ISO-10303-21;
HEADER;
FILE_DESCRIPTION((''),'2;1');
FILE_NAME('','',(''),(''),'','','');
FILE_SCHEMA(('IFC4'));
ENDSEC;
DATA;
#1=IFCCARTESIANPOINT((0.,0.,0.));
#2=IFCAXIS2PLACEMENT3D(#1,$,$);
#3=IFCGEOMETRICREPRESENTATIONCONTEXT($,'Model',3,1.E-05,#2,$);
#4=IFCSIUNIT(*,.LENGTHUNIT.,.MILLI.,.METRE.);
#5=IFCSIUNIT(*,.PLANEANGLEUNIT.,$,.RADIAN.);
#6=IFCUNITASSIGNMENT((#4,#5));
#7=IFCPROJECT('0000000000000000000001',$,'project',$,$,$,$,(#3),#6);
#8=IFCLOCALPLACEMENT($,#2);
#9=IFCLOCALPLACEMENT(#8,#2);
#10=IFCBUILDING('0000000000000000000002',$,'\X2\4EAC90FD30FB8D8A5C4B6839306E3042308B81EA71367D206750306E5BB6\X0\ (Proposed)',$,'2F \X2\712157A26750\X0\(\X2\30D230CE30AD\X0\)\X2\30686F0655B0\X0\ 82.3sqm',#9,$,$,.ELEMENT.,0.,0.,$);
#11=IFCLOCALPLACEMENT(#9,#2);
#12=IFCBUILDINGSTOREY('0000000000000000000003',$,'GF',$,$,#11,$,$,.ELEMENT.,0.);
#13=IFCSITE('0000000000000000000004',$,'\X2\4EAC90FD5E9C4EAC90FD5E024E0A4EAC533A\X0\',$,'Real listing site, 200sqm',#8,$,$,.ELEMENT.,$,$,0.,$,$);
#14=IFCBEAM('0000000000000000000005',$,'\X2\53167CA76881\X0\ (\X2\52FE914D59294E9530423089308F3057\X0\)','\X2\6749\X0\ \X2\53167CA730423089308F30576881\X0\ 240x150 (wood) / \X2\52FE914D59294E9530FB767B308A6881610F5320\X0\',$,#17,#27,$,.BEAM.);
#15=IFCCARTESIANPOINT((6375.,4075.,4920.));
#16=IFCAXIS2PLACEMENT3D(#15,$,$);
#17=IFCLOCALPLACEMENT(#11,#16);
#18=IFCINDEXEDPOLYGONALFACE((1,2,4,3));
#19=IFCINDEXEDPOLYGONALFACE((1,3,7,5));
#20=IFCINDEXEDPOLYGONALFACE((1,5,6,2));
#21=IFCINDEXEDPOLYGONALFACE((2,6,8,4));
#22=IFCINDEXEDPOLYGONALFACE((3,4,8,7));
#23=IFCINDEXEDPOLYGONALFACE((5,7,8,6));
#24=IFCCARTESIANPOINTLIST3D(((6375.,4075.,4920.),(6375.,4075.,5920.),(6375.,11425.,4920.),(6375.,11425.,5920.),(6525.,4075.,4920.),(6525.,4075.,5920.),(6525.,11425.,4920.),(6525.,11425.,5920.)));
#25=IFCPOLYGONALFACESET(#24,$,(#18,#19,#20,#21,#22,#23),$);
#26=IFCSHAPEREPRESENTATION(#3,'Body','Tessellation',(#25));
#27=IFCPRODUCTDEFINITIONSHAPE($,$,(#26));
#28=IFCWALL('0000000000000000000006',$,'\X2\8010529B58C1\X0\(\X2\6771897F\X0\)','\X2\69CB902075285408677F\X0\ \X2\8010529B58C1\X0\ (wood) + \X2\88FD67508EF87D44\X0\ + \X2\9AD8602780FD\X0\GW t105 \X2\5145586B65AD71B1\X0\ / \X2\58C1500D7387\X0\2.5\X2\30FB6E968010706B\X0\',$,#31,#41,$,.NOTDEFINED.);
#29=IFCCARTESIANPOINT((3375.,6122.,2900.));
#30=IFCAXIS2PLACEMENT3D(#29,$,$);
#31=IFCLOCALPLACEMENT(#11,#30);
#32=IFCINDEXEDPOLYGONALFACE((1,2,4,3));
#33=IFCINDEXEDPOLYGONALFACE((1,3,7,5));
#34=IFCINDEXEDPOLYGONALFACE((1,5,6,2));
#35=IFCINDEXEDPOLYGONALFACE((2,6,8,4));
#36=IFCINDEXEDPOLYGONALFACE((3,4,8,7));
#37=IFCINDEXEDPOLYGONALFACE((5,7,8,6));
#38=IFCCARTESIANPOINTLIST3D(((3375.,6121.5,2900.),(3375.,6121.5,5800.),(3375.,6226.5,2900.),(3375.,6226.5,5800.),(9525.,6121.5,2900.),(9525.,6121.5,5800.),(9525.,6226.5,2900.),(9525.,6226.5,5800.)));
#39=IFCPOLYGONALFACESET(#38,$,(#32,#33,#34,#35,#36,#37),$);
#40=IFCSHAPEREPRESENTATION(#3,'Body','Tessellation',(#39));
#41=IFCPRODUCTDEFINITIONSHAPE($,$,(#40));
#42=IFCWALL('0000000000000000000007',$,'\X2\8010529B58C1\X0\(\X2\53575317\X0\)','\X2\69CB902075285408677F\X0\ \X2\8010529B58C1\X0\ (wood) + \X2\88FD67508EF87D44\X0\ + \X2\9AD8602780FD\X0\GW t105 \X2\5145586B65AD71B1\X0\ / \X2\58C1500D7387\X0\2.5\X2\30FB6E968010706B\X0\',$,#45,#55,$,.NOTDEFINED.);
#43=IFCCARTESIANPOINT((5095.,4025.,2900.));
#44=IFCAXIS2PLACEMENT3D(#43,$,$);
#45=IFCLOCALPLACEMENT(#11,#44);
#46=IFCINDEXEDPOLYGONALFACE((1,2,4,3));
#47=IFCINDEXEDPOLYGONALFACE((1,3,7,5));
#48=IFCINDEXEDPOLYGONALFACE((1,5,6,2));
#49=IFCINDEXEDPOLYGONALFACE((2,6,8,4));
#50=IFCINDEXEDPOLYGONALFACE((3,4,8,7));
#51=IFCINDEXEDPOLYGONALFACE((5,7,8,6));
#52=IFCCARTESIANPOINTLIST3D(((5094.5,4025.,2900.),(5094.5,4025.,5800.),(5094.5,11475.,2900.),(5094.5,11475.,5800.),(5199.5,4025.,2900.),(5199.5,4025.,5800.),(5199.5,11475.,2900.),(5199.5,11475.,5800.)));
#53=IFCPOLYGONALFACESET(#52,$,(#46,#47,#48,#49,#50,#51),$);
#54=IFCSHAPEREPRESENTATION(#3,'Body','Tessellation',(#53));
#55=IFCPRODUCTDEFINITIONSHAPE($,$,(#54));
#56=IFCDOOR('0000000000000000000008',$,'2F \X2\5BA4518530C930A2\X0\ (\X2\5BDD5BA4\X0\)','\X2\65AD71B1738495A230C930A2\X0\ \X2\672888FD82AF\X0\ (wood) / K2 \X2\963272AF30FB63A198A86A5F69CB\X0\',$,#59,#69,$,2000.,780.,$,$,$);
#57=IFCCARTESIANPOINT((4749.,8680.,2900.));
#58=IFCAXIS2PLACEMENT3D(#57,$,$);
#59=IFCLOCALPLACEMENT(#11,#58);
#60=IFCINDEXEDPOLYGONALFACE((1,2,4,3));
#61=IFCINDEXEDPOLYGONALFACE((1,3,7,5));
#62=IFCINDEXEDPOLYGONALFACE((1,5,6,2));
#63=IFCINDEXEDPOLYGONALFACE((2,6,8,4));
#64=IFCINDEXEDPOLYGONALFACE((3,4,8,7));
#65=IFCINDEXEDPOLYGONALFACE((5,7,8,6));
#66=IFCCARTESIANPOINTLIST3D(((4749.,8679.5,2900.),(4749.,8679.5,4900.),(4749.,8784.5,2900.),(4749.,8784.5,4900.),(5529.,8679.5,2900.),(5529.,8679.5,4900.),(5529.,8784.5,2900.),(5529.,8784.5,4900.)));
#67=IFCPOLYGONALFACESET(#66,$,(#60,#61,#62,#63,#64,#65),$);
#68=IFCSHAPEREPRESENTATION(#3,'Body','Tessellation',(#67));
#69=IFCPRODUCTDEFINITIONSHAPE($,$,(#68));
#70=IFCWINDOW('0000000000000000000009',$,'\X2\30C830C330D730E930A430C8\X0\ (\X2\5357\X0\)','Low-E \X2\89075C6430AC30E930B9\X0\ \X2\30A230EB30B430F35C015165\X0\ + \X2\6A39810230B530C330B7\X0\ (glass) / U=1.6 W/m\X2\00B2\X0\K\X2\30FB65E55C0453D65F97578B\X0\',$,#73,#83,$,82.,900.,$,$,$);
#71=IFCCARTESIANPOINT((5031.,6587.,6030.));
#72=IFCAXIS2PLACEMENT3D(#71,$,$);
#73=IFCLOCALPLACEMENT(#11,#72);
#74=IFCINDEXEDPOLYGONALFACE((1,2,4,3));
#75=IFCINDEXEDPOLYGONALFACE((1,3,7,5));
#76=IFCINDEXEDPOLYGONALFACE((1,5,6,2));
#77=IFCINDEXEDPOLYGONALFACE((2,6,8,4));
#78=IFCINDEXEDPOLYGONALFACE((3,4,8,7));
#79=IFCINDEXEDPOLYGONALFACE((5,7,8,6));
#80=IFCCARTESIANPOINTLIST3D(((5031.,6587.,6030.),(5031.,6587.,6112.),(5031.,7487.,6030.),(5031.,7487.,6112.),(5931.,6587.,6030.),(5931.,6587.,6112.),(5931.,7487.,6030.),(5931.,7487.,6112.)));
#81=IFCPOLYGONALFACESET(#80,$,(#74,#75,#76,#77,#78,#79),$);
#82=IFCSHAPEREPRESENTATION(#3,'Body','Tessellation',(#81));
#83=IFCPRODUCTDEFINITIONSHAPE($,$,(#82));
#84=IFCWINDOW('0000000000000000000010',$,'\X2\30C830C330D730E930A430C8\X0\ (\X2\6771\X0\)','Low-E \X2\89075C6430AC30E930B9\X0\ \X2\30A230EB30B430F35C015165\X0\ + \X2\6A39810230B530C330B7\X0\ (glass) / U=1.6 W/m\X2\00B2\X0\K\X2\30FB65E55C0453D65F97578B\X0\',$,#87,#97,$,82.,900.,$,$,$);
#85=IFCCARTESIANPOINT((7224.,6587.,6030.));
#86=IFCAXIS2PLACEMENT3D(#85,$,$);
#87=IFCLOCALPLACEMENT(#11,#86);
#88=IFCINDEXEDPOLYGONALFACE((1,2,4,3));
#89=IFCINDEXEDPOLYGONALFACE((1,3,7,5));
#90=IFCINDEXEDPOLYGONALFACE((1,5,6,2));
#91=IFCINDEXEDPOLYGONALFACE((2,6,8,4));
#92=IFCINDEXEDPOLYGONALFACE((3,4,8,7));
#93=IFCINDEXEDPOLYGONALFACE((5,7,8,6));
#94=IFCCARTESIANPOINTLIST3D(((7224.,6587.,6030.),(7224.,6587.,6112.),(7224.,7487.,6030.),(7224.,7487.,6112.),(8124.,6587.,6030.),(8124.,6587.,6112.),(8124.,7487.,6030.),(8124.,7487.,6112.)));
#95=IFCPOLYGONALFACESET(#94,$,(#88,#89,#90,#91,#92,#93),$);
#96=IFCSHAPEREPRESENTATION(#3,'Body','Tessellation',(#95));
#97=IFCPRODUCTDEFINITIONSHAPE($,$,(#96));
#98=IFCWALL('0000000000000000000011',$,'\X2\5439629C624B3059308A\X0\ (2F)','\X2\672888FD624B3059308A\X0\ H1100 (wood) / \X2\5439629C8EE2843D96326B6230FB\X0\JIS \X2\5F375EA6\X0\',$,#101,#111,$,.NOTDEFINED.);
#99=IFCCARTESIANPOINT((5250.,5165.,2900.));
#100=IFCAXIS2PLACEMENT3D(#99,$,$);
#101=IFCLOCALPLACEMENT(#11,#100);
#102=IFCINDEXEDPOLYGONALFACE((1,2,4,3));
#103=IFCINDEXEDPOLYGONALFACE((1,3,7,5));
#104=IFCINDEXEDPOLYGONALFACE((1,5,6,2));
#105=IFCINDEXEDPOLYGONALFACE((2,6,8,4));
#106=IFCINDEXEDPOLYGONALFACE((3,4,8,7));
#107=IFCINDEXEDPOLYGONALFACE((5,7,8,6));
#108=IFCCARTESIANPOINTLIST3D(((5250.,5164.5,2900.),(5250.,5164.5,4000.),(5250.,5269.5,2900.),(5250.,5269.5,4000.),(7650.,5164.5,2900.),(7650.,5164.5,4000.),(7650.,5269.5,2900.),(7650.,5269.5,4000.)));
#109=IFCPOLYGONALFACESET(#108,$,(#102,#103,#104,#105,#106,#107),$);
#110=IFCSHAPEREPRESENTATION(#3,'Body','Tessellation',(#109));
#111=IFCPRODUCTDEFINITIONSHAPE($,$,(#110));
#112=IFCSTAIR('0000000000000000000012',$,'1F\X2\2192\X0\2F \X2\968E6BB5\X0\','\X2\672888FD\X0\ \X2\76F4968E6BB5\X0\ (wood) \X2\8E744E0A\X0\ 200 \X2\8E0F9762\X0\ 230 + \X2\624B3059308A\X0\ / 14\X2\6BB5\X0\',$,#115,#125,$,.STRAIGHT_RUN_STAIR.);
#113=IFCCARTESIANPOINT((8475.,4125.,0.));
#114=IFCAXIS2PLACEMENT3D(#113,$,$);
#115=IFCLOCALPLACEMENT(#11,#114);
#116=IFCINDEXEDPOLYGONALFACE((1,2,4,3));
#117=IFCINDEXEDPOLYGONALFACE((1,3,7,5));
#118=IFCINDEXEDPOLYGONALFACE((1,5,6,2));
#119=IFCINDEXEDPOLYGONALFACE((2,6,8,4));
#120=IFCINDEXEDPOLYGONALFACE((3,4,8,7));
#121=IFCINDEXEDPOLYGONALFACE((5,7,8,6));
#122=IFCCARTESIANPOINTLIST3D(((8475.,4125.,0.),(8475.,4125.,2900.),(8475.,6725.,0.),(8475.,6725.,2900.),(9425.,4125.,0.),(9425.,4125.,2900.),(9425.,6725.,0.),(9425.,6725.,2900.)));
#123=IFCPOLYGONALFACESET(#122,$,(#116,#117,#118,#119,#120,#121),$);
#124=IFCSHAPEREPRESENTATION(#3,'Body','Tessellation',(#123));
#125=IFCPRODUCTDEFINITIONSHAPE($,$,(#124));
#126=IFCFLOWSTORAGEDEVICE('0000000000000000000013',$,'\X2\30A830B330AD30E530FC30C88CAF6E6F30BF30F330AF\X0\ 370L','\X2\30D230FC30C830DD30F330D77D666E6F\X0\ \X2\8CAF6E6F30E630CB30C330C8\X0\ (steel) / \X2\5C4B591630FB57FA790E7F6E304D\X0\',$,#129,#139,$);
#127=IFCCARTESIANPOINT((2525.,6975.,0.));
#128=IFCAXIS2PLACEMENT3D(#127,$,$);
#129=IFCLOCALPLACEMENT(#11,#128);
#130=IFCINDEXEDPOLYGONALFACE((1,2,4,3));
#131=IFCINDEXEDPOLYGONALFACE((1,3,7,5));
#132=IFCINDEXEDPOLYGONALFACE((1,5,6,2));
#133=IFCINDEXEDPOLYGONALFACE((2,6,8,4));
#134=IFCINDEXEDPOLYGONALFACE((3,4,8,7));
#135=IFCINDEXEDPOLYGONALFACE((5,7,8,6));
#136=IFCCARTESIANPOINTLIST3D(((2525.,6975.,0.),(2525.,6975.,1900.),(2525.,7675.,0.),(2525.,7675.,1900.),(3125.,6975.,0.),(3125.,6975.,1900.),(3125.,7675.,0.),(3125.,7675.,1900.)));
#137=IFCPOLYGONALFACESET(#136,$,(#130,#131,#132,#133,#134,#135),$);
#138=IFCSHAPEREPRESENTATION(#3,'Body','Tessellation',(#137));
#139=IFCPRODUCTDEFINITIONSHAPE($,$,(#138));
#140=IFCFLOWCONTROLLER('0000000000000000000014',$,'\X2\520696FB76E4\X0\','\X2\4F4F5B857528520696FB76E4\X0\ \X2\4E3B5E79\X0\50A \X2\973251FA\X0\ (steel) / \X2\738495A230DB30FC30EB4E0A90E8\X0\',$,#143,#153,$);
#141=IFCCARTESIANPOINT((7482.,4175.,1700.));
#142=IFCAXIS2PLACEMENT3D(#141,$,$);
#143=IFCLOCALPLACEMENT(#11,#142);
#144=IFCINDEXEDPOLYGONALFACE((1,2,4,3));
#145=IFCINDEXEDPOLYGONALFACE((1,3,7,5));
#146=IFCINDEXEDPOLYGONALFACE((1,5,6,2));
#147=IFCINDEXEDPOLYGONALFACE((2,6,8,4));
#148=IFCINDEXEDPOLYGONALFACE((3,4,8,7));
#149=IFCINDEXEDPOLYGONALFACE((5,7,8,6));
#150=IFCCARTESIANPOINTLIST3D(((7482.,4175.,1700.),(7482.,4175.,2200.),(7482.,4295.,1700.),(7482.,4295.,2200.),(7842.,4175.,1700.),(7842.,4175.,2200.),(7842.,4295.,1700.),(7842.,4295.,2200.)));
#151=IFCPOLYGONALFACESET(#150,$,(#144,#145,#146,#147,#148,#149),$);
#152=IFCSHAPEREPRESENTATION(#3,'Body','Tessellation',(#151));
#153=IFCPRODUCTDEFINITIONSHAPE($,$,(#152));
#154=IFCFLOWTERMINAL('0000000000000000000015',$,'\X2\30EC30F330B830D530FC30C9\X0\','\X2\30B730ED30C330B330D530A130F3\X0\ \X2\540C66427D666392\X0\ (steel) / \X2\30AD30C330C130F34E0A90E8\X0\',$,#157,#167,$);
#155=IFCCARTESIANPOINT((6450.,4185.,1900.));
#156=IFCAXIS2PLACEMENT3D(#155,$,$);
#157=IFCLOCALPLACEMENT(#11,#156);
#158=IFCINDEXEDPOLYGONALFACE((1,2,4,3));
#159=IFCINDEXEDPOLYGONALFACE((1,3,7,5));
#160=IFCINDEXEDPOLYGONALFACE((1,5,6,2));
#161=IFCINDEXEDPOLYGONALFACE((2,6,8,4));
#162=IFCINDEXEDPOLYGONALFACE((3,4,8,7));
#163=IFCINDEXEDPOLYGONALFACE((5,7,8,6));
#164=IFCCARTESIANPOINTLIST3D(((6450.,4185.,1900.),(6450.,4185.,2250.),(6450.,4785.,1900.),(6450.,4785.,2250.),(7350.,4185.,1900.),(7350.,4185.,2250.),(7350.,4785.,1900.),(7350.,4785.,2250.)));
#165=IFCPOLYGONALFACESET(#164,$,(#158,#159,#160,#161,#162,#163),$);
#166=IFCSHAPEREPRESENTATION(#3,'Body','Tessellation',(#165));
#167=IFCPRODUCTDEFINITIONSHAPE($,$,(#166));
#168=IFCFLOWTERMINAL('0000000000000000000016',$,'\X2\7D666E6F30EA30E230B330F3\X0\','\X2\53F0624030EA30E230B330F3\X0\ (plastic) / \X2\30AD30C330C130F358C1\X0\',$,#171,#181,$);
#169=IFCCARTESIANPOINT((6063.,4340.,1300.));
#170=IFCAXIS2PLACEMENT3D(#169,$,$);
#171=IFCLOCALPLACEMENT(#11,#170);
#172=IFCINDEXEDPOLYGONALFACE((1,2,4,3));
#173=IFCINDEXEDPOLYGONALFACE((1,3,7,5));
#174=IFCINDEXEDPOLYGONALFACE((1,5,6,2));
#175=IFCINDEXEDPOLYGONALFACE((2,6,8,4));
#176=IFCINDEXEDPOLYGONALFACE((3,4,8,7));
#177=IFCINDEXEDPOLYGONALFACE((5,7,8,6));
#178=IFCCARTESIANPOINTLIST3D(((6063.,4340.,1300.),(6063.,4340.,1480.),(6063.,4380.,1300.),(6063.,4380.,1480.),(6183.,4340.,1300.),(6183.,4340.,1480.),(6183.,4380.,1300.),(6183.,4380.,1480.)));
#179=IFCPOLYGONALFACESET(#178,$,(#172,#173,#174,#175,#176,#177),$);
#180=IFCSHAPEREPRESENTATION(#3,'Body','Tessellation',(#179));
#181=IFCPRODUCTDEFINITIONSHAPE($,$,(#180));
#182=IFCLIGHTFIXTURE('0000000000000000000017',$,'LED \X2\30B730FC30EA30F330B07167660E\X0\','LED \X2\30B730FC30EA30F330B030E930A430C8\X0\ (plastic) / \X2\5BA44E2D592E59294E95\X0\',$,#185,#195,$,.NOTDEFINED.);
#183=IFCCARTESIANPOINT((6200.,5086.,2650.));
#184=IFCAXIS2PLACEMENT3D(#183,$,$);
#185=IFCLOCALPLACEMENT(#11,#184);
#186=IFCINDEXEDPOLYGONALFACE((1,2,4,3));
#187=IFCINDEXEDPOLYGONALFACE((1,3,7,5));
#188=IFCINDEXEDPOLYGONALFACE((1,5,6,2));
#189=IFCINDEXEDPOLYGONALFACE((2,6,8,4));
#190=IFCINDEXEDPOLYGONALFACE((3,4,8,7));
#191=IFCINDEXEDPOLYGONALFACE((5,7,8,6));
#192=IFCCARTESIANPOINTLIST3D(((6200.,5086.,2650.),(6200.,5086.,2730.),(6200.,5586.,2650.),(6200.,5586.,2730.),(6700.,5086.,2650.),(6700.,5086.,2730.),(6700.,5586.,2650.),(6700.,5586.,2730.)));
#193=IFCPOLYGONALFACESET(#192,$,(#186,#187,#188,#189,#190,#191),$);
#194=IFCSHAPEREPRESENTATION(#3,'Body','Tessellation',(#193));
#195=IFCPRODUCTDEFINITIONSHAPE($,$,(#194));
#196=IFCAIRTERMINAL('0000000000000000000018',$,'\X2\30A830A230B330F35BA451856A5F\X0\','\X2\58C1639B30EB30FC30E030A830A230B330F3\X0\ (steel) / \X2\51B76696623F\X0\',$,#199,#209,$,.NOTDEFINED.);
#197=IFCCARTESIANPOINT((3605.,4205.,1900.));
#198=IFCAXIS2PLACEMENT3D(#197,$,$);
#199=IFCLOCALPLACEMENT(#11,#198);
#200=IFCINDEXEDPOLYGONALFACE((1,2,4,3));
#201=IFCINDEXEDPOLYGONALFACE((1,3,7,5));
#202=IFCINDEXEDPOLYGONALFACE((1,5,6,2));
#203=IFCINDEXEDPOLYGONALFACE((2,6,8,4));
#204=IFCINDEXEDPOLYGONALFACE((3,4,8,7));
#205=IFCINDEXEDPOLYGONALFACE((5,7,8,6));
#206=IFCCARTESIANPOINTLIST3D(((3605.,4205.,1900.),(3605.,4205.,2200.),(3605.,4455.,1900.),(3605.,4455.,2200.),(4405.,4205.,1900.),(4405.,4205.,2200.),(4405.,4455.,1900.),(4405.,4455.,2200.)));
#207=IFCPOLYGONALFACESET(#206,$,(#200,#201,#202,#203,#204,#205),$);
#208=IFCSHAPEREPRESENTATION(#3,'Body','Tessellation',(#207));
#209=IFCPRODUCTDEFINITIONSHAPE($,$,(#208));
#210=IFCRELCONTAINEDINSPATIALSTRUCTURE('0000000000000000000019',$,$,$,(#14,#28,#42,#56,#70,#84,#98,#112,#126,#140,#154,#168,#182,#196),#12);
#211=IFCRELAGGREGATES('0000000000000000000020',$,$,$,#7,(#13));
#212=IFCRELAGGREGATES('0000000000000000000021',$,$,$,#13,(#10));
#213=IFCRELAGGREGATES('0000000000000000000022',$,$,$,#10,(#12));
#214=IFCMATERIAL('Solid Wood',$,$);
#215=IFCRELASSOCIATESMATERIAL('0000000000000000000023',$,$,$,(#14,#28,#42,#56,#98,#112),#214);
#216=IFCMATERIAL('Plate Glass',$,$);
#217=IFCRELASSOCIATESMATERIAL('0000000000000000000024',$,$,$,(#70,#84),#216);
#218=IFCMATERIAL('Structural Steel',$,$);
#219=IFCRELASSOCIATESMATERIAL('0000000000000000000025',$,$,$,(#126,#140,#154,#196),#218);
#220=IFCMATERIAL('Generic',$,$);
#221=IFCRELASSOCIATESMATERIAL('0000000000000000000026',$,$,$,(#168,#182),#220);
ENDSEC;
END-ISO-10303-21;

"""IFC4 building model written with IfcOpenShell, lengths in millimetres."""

from ifc_helpers import new_model, si_unit, frame, frame_2d, origin, place, context, project, spatial, rectangle, extrude, material, element, fill, save


model = new_model("IFC4")

# Units and contexts
model_context = context("Model", 3, precision=1e-05, world=origin())
ifc_project = project(units=[si_unit("LENGTHUNIT", "METRE", prefix="MILLI"), si_unit("PLANEANGLEUNIT", "RADIAN")], contexts=[model_context])

# Site, building, storey
site_placement = place(None, origin())
site = spatial("IfcSite", under=ifc_project, at=site_placement, Name="京都府京都市上京区", ObjectType="Real listing site, 200sqm", CompositionType="ELEMENT", RefElevation=0.0)
building_placement = place(site_placement, origin())
building = spatial("IfcBuilding", under=site, at=building_placement, Name="京都・越屋根のある自然素材の家 (Proposed)", ObjectType="2F 無垢材(ヒノキ)と漆喰 82.3sqm", CompositionType="ELEMENT", ElevationOfRefHeight=0.0, ElevationOfTerrain=0.0)
storey_placement = place(building_placement, origin())
storey = spatial("IfcBuildingStorey", under=building, at=storey_placement, Name="GF", CompositionType="ELEMENT", Elevation=0.0)

# Shared definitions
ifc_material_1 = material(Name="Solid Wood")

# Beam
beam_placement = place(storey_placement, frame((6375.0, 4075.0, 4920.0)))
element("IfcBeam", 1, at=beam_placement, inside=storey, material=ifc_material_1, Name="化粧梁 (勾配天井あらわし)", Description="杉 化粧あらわし梁 240x150 (wood) / 勾配天井・登り梁意匠", PredefinedType="BEAM", context=model_context, shape_type="SweptSolid", body=[
    extrude(rectangle(XDim=150.0, YDim=7350.0, at=frame_2d((75.0, 3675.0))), frame((6375.0, 4075.0, 4920.0)), (0.0, 0.0, 1.0), 1000.0),
])

# Wall
wall_1_placement = place(storey_placement, frame((3375.0, 6122.0, 2900.0)))
element("IfcWall", 2, at=wall_1_placement, inside=storey, material=ifc_material_1, Name="耐力壁(東西)", Description="構造用合板 耐力壁 (wood) + 製材軸組 + 高性能GW t105 充填断熱 / 壁倍率2.5・準耐火", PredefinedType="NOTDEFINED", context=model_context, shape_type="SweptSolid", body=[
    extrude(rectangle(XDim=6150.0, YDim=105.0, at=frame_2d((3075.0, 52.0))), frame((3375.0, 6122.0, 2900.0)), (0.0, 0.0, 1.0), 2900.0),
])

# Wall, opening, door
wall_2_placement = place(storey_placement, frame((5095.0, 4025.0, 2900.0)))
wall_2 = element("IfcWall", 3, at=wall_2_placement, inside=storey, material=ifc_material_1, Name="耐力壁(南北)", Description="構造用合板 耐力壁 (wood) + 製材軸組 + 高性能GW t105 充填断熱 / 壁倍率2.5・準耐火", PredefinedType="NOTDEFINED", context=model_context, shape_type="SweptSolid", body=[
    extrude(rectangle(XDim=105.0, YDim=7450.0, at=frame_2d((52.0, 3725.0))), frame((5095.0, 4025.0, 2900.0)), (0.0, 0.0, 1.0), 2900.0),
])
opening_placement = place(storey_placement, frame((4749.0, 8680.0, 2900.0)))
opening = element("IfcOpeningElement", 4, at=opening_placement, cuts=wall_2, PredefinedType="NOTDEFINED", context=model_context, shape_type="SweptSolid", body=[
    extrude(rectangle(XDim=780.0, YDim=105.0, at=frame_2d((390.0, 52.0))), frame((4749.0, 8680.0, 2900.0)), (0.0, 0.0, 1.0), 2000.0),
])
door_placement = place(storey_placement, frame((4749.0, 8680.0, 2900.0)))
door = element("IfcDoor", 5, at=door_placement, inside=storey, material=ifc_material_1, Name="2F 室内ドア (寝室)", Description="断熱玄関ドア 木製芯 (wood) / K2 防犯・採風機構", OverallHeight=2000.0, OverallWidth=780.0, context=model_context, shape_type="SweptSolid", body=[
    extrude(rectangle(XDim=780.0, YDim=105.0, at=frame_2d((390.0, 52.0))), frame((4749.0, 8680.0, 2900.0)), (0.0, 0.0, 1.0), 2000.0),
])
fill(opening, door)

# Windows
ifc_material_2 = material(Name="Plate Glass")
window_1_placement = place(storey_placement, frame((5031.0, 6587.0, 6030.0)))
element("IfcWindow", 6, at=window_1_placement, inside=storey, material=ifc_material_2, Name="トップライト (南)", Description="Low-E 複層ガラス アルゴン封入 + 樹脂サッシ (glass) / U=1.6 W/m²K・日射取得型", OverallHeight=82.0, OverallWidth=900.0, context=model_context, shape_type="SweptSolid", body=[
    extrude(rectangle(XDim=900.0, YDim=900.0, at=frame_2d((450.0, 450.0))), frame((5031.0, 6587.0, 6030.0)), (0.0, 0.0, 1.0), 82.0),
])
window_2_placement = place(storey_placement, frame((7224.0, 6587.0, 6030.0)))
element("IfcWindow", 7, at=window_2_placement, inside=storey, material=ifc_material_2, Name="トップライト (東)", Description="Low-E 複層ガラス アルゴン封入 + 樹脂サッシ (glass) / U=1.6 W/m²K・日射取得型", OverallHeight=82.0, OverallWidth=900.0, context=model_context, shape_type="SweptSolid", body=[
    extrude(rectangle(XDim=900.0, YDim=900.0, at=frame_2d((450.0, 450.0))), frame((7224.0, 6587.0, 6030.0)), (0.0, 0.0, 1.0), 82.0),
])

# Wall
wall_3_placement = place(storey_placement, frame((5250.0, 5165.0, 2900.0)))
element("IfcWall", 8, at=wall_3_placement, inside=storey, material=ifc_material_1, Name="吹抜手すり (2F)", Description="木製手すり H1100 (wood) / 吹抜転落防止・JIS 強度", PredefinedType="NOTDEFINED", context=model_context, shape_type="SweptSolid", body=[
    extrude(rectangle(XDim=2400.0, YDim=105.0, at=frame_2d((1200.0, 52.0))), frame((5250.0, 5165.0, 2900.0)), (0.0, 0.0, 1.0), 1100.0),
])

# Stair
stair_placement = place(storey_placement, frame((8475.0, 4125.0, 0.0)))
element("IfcStair", 9, at=stair_placement, inside=storey, material=ifc_material_1, Name="1F→2F 階段", Description="木製 直階段 (wood) 蹴上 200 踏面 230 + 手すり / 14段", PredefinedType="STRAIGHT_RUN_STAIR", context=model_context, shape_type="SweptSolid", body=[
    extrude(rectangle(XDim=950.0, YDim=2600.0, at=frame_2d((475.0, 1300.0))), frame((8475.0, 4125.0, 0.0)), (0.0, 0.0, 1.0), 2900.0),
])

# Flow storage device
ifc_material_3 = material(Name="Structural Steel")
flow_storage_device_placement = place(storey_placement, frame((2525.0, 6975.0, 0.0)))
element("IfcFlowStorageDevice", 10, at=flow_storage_device_placement, inside=storey, material=ifc_material_3, Name="エコキュート貯湯タンク 370L", Description="ヒートポンプ給湯 貯湯ユニット (steel) / 屋外・基礎置き", context=model_context, shape_type="SweptSolid", body=[
    extrude(rectangle(XDim=600.0, YDim=700.0, at=frame_2d((300.0, 350.0))), frame((2525.0, 6975.0, 0.0)), (0.0, 0.0, 1.0), 1900.0),
])

# Flow controller
flow_controller_placement = place(storey_placement, frame((7482.0, 4175.0, 1700.0)))
element("IfcFlowController", 11, at=flow_controller_placement, inside=storey, material=ifc_material_3, Name="分電盤", Description="住宅用分電盤 主幹50A 露出 (steel) / 玄関ホール上部", context=model_context, shape_type="SweptSolid", body=[
    extrude(rectangle(XDim=360.0, YDim=120.0, at=frame_2d((180.0, 60.0))), frame((7482.0, 4175.0, 1700.0)), (0.0, 0.0, 1.0), 500.0),
])

# Flow terminals
flow_terminal_1_placement = place(storey_placement, frame((6450.0, 4185.0, 1900.0)))
element("IfcFlowTerminal", 12, at=flow_terminal_1_placement, inside=storey, material=ifc_material_3, Name="レンジフード", Description="シロッコファン 同時給排 (steel) / キッチン上部", context=model_context, shape_type="SweptSolid", body=[
    extrude(rectangle(XDim=900.0, YDim=600.0, at=frame_2d((450.0, 300.0))), frame((6450.0, 4185.0, 1900.0)), (0.0, 0.0, 1.0), 350.0),
])
ifc_material_4 = material(Name="Generic")
flow_terminal_2_placement = place(storey_placement, frame((6063.0, 4340.0, 1300.0)))
element("IfcFlowTerminal", 13, at=flow_terminal_2_placement, inside=storey, material=ifc_material_4, Name="給湯リモコン", Description="台所リモコン (plastic) / キッチン壁", context=model_context, shape_type="SweptSolid", body=[
    extrude(rectangle(XDim=120.0, YDim=40.0, at=frame_2d((60.0, 20.0))), frame((6063.0, 4340.0, 1300.0)), (0.0, 0.0, 1.0), 180.0),
])

# Light fixture
light_fixture_1_placement = place(storey_placement, frame((6200.0, 5086.0, 2650.0)))
element("IfcLightFixture", 14, at=light_fixture_1_placement, inside=storey, material=ifc_material_4, Name="LED シーリング照明", Description="LED シーリングライト (plastic) / 室中央天井", PredefinedType="NOTDEFINED", context=model_context, shape_type="SweptSolid", body=[
    extrude(rectangle(XDim=500.0, YDim=500.0, at=frame_2d((250.0, 250.0))), frame((6200.0, 5086.0, 2650.0)), (0.0, 0.0, 1.0), 80.0),
])

# Air terminal
air_terminal_1_placement = place(storey_placement, frame((3605.0, 4205.0, 1900.0)))
element("IfcAirTerminal", 15, at=air_terminal_1_placement, inside=storey, material=ifc_material_3, Name="エアコン室内機", Description="壁掛ルームエアコン (steel) / 冷暖房", PredefinedType="NOTDEFINED", context=model_context, shape_type="SweptSolid", body=[
    extrude(rectangle(XDim=800.0, YDim=250.0, at=frame_2d((400.0, 125.0))), frame((3605.0, 4205.0, 1900.0)), (0.0, 0.0, 1.0), 300.0),
])

save(model, "model.ifc")
